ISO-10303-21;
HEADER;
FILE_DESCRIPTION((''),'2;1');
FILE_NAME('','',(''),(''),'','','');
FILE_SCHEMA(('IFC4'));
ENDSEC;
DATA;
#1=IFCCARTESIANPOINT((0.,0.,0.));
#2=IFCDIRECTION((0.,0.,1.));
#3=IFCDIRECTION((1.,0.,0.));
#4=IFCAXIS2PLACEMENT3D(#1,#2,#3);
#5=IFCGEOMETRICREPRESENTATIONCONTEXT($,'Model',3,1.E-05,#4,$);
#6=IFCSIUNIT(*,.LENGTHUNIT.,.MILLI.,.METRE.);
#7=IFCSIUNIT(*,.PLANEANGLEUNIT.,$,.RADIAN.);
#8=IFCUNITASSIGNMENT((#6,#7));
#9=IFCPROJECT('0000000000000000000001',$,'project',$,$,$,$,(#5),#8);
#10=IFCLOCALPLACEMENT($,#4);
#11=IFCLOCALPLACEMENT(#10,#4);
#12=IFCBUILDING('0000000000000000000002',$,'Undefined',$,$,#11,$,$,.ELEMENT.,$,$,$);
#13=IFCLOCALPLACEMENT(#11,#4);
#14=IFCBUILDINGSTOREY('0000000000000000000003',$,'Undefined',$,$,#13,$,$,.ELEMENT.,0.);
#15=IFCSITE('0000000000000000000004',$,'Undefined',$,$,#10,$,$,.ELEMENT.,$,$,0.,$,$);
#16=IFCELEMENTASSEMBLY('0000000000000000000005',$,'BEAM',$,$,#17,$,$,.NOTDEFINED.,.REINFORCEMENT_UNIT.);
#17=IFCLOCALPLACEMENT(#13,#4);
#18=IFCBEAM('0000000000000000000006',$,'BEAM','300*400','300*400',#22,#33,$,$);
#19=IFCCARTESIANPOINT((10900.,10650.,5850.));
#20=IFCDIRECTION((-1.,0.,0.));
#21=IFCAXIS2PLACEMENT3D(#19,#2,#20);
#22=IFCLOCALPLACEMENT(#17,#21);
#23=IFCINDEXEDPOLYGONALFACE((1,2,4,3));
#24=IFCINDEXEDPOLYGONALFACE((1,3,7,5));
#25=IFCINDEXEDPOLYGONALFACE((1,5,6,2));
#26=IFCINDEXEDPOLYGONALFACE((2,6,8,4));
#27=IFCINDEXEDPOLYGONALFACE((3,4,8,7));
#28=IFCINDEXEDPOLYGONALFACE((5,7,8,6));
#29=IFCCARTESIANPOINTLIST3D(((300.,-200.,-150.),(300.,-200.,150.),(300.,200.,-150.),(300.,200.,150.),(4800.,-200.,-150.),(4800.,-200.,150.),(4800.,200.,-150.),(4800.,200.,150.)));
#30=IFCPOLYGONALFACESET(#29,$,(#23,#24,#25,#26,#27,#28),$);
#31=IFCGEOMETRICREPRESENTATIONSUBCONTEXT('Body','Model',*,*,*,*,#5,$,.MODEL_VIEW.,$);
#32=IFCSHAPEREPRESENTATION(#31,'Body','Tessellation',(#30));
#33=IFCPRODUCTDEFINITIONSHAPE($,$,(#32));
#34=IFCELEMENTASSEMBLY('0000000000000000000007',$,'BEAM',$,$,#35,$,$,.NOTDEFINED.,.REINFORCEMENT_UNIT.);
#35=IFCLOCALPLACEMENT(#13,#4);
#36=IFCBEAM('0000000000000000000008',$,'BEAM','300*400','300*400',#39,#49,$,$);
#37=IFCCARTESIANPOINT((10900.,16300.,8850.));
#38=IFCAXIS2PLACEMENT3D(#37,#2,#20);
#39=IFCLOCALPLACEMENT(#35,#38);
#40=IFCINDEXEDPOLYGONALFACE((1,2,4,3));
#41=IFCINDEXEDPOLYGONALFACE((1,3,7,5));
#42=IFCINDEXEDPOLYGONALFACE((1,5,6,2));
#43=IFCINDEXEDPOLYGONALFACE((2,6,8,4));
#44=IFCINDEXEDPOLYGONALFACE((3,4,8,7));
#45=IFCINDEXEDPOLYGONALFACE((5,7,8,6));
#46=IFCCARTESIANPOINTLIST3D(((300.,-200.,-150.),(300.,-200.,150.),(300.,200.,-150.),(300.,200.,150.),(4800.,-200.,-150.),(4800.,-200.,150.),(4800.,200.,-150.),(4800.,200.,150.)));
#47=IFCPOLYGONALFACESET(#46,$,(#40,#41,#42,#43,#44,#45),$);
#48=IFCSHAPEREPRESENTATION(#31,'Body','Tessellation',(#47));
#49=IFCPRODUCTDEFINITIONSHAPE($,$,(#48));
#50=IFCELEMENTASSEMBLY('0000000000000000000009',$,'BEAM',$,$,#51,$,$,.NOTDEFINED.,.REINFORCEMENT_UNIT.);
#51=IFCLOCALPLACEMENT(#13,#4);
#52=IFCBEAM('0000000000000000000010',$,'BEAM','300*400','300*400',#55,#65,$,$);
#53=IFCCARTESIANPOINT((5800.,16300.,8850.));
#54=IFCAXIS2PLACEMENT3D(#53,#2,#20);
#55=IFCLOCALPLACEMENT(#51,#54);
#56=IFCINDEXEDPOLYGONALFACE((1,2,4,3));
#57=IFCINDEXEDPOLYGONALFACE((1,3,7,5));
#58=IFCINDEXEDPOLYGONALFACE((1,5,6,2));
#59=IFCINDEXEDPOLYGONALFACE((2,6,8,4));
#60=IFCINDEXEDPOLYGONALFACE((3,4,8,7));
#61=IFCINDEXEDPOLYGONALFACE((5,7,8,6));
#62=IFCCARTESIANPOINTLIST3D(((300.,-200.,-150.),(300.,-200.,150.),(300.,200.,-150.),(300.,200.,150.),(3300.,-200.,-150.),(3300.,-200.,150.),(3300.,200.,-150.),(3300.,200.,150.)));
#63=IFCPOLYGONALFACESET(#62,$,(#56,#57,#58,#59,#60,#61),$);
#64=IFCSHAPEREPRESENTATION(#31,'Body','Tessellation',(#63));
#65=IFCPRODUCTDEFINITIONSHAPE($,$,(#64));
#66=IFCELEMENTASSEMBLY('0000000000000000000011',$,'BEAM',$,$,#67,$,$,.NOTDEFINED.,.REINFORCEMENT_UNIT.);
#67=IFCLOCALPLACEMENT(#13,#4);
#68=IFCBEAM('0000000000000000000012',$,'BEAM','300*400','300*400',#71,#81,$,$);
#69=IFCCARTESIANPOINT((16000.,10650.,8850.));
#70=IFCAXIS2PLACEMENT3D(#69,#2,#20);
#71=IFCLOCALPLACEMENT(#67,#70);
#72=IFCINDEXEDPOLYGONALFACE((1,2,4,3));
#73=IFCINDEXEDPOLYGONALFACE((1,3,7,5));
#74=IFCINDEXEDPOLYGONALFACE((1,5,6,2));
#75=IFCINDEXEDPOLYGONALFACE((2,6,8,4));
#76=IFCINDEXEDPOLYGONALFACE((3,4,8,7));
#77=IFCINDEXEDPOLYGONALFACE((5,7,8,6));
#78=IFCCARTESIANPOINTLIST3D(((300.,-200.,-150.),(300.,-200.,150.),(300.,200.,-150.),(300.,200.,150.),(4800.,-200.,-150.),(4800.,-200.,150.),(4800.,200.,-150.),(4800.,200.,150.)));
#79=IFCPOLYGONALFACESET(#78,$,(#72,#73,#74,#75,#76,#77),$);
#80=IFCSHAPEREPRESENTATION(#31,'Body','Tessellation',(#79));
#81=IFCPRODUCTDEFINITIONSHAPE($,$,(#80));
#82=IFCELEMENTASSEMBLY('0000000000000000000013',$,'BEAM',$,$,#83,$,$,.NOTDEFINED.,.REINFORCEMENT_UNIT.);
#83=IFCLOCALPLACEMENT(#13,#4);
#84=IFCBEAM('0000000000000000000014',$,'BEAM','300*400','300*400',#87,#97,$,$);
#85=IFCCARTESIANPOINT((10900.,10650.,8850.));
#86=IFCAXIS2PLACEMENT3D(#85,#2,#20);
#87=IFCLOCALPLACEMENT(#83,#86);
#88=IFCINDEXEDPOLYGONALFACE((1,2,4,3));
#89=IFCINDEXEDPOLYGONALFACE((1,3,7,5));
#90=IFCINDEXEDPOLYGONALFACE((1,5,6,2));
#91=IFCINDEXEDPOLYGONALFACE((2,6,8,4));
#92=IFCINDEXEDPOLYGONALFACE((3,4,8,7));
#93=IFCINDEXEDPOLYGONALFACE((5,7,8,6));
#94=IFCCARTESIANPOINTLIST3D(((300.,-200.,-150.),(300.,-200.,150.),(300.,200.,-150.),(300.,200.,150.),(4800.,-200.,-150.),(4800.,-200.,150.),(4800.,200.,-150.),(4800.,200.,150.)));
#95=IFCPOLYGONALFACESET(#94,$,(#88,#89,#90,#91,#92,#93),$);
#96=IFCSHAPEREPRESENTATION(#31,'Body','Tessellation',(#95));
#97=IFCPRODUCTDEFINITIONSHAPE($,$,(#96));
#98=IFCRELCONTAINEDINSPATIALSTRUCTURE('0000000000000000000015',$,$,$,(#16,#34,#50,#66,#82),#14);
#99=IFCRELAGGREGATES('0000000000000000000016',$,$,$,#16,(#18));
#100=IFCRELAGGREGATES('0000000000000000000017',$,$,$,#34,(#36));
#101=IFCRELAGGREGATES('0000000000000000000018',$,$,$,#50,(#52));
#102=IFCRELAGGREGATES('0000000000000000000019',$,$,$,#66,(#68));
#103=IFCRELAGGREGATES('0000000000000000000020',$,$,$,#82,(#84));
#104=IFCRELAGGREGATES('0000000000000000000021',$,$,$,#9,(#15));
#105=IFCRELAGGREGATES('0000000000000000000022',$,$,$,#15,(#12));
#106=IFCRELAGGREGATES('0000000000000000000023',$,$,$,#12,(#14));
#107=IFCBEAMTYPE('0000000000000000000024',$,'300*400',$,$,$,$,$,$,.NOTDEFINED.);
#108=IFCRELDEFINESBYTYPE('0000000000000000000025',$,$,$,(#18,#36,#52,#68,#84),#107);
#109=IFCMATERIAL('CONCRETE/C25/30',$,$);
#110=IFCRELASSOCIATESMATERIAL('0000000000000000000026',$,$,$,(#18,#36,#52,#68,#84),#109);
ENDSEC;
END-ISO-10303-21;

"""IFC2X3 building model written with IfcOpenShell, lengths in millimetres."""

from ifc_helpers import new_model, si_unit, frame, origin_with_axes, origin_2d_with_axis, place, context, subcontext, project, spatial, rectangle, extrude, material, type_object, element, aggregate, save


model = new_model("IFC2X3")

# Units and contexts
model_context = context("Model", 3, precision=1e-05, world=origin_with_axes())
body_context = subcontext(model_context, "Body", "Model", "MODEL_VIEW")
ifc_project = project(units=[si_unit("LENGTHUNIT", "METRE", prefix="MILLI"), si_unit("PLANEANGLEUNIT", "RADIAN")], contexts=[model_context])

# Site, building, storey
site_placement = place(None, origin_with_axes())
site = spatial("IfcSite", under=ifc_project, at=site_placement, Name="Undefined", CompositionType="ELEMENT", RefElevation=0.0)
building_placement = place(site_placement, origin_with_axes())
building = spatial("IfcBuilding", under=site, at=building_placement, Name="Undefined", CompositionType="ELEMENT")
storey_placement = place(building_placement, origin_with_axes())
storey = spatial("IfcBuildingStorey", under=building, at=storey_placement, Name="Undefined", CompositionType="ELEMENT", Elevation=0.0)

# Shared definitions
ifc_material = material(Name="CONCRETE/C25/30")

# Element assemblies, beams
beam_type_1 = type_object("IfcBeamType", Name="300*400", PredefinedType="NOTDEFINED")
assembly_1_placement = place(storey_placement, origin_with_axes())
assembly_1 = element("IfcElementAssembly", 1, at=assembly_1_placement, inside=storey, Name="BEAM", AssemblyPlace="NOTDEFINED", PredefinedType="REINFORCEMENT_UNIT")
beam_1_placement = place(assembly_1_placement, frame((10900.0, 10650.0, 5850.0), z_axis=(0.0, 0.0, 1.0), x_axis=(-1.0, 0.0, 0.0)))
beam_1 = element("IfcBeam", 2, at=beam_1_placement, type_object=beam_type_1, material=ifc_material, Name="BEAM", Description="300*400", ObjectType="300*400", context=body_context, shape_type="SweptSolid", body=[
    extrude(rectangle(XDim=400.0, YDim=300.0, at=origin_2d_with_axis()), frame((4800.0, 0.0, 0.0), z_axis=(-1.0, 0.0, 0.0), x_axis=(0.0, -1.0, 0.0)), (0.0, 0.0, 1.0), 4500.0),
])
aggregate(assembly_1, [beam_1])
assembly_2_placement = place(storey_placement, origin_with_axes())
assembly_2 = element("IfcElementAssembly", 3, at=assembly_2_placement, inside=storey, Name="BEAM", AssemblyPlace="NOTDEFINED", PredefinedType="REINFORCEMENT_UNIT")
beam_2_placement = place(assembly_2_placement, frame((10900.0, 16300.0, 8850.0), z_axis=(0.0, 0.0, 1.0), x_axis=(-1.0, 0.0, 0.0)))
beam_2 = element("IfcBeam", 4, at=beam_2_placement, type_object=beam_type_1, material=ifc_material, Name="BEAM", Description="300*400", ObjectType="300*400", context=body_context, shape_type="SweptSolid", body=[
    extrude(rectangle(XDim=400.0, YDim=300.0, at=origin_2d_with_axis()), frame((4800.0, 0.0, 0.0), z_axis=(-1.0, 0.0, 0.0), x_axis=(0.0, -1.0, 0.0)), (0.0, 0.0, 1.0), 4500.0),
])
aggregate(assembly_2, [beam_2])
assembly_3_placement = place(storey_placement, origin_with_axes())
assembly_3 = element("IfcElementAssembly", 5, at=assembly_3_placement, inside=storey, Name="BEAM", AssemblyPlace="NOTDEFINED", PredefinedType="REINFORCEMENT_UNIT")
beam_3_placement = place(assembly_3_placement, frame((5800.0, 16300.0, 8850.0), z_axis=(0.0, 0.0, 1.0), x_axis=(-1.0, 0.0, 0.0)))
beam_3 = element("IfcBeam", 6, at=beam_3_placement, type_object=beam_type_1, material=ifc_material, Name="BEAM", Description="300*400", ObjectType="300*400", context=body_context, shape_type="SweptSolid", body=[
    extrude(rectangle(XDim=400.0, YDim=300.0, at=origin_2d_with_axis()), frame((3300.0, 0.0, 0.0), z_axis=(-1.0, 0.0, 0.0), x_axis=(0.0, -1.0, 0.0)), (0.0, 0.0, 1.0), 3000.0),
])
aggregate(assembly_3, [beam_3])
assembly_4_placement = place(storey_placement, origin_with_axes())
assembly_4 = element("IfcElementAssembly", 7, at=assembly_4_placement, inside=storey, Name="BEAM", AssemblyPlace="NOTDEFINED", PredefinedType="REINFORCEMENT_UNIT")
beam_4_placement = place(assembly_4_placement, frame((16000.0, 10650.0, 8850.0), z_axis=(0.0, 0.0, 1.0), x_axis=(-1.0, 0.0, 0.0)))
beam_4 = element("IfcBeam", 8, at=beam_4_placement, type_object=beam_type_1, material=ifc_material, Name="BEAM", Description="300*400", ObjectType="300*400", context=body_context, shape_type="SweptSolid", body=[
    extrude(rectangle(XDim=400.0, YDim=300.0, at=origin_2d_with_axis()), frame((4800.0, 0.0, 0.0), z_axis=(-1.0, 0.0, 0.0), x_axis=(0.0, -1.0, 0.0)), (0.0, 0.0, 1.0), 4500.0),
])
aggregate(assembly_4, [beam_4])
assembly_5_placement = place(storey_placement, origin_with_axes())
assembly_5 = element("IfcElementAssembly", 9, at=assembly_5_placement, inside=storey, Name="BEAM", AssemblyPlace="NOTDEFINED", PredefinedType="REINFORCEMENT_UNIT")
beam_5_placement = place(assembly_5_placement, frame((10900.0, 10650.0, 8850.0), z_axis=(0.0, 0.0, 1.0), x_axis=(-1.0, 0.0, 0.0)))
beam_5 = element("IfcBeam", 10, at=beam_5_placement, type_object=beam_type_1, material=ifc_material, Name="BEAM", Description="300*400", ObjectType="300*400", context=body_context, shape_type="SweptSolid", body=[
    extrude(rectangle(XDim=400.0, YDim=300.0, at=origin_2d_with_axis()), frame((4800.0, 0.0, 0.0), z_axis=(-1.0, 0.0, 0.0), x_axis=(0.0, -1.0, 0.0)), (0.0, 0.0, 1.0), 4500.0),
])
aggregate(assembly_5, [beam_5])

save(model, "model.ifc")
